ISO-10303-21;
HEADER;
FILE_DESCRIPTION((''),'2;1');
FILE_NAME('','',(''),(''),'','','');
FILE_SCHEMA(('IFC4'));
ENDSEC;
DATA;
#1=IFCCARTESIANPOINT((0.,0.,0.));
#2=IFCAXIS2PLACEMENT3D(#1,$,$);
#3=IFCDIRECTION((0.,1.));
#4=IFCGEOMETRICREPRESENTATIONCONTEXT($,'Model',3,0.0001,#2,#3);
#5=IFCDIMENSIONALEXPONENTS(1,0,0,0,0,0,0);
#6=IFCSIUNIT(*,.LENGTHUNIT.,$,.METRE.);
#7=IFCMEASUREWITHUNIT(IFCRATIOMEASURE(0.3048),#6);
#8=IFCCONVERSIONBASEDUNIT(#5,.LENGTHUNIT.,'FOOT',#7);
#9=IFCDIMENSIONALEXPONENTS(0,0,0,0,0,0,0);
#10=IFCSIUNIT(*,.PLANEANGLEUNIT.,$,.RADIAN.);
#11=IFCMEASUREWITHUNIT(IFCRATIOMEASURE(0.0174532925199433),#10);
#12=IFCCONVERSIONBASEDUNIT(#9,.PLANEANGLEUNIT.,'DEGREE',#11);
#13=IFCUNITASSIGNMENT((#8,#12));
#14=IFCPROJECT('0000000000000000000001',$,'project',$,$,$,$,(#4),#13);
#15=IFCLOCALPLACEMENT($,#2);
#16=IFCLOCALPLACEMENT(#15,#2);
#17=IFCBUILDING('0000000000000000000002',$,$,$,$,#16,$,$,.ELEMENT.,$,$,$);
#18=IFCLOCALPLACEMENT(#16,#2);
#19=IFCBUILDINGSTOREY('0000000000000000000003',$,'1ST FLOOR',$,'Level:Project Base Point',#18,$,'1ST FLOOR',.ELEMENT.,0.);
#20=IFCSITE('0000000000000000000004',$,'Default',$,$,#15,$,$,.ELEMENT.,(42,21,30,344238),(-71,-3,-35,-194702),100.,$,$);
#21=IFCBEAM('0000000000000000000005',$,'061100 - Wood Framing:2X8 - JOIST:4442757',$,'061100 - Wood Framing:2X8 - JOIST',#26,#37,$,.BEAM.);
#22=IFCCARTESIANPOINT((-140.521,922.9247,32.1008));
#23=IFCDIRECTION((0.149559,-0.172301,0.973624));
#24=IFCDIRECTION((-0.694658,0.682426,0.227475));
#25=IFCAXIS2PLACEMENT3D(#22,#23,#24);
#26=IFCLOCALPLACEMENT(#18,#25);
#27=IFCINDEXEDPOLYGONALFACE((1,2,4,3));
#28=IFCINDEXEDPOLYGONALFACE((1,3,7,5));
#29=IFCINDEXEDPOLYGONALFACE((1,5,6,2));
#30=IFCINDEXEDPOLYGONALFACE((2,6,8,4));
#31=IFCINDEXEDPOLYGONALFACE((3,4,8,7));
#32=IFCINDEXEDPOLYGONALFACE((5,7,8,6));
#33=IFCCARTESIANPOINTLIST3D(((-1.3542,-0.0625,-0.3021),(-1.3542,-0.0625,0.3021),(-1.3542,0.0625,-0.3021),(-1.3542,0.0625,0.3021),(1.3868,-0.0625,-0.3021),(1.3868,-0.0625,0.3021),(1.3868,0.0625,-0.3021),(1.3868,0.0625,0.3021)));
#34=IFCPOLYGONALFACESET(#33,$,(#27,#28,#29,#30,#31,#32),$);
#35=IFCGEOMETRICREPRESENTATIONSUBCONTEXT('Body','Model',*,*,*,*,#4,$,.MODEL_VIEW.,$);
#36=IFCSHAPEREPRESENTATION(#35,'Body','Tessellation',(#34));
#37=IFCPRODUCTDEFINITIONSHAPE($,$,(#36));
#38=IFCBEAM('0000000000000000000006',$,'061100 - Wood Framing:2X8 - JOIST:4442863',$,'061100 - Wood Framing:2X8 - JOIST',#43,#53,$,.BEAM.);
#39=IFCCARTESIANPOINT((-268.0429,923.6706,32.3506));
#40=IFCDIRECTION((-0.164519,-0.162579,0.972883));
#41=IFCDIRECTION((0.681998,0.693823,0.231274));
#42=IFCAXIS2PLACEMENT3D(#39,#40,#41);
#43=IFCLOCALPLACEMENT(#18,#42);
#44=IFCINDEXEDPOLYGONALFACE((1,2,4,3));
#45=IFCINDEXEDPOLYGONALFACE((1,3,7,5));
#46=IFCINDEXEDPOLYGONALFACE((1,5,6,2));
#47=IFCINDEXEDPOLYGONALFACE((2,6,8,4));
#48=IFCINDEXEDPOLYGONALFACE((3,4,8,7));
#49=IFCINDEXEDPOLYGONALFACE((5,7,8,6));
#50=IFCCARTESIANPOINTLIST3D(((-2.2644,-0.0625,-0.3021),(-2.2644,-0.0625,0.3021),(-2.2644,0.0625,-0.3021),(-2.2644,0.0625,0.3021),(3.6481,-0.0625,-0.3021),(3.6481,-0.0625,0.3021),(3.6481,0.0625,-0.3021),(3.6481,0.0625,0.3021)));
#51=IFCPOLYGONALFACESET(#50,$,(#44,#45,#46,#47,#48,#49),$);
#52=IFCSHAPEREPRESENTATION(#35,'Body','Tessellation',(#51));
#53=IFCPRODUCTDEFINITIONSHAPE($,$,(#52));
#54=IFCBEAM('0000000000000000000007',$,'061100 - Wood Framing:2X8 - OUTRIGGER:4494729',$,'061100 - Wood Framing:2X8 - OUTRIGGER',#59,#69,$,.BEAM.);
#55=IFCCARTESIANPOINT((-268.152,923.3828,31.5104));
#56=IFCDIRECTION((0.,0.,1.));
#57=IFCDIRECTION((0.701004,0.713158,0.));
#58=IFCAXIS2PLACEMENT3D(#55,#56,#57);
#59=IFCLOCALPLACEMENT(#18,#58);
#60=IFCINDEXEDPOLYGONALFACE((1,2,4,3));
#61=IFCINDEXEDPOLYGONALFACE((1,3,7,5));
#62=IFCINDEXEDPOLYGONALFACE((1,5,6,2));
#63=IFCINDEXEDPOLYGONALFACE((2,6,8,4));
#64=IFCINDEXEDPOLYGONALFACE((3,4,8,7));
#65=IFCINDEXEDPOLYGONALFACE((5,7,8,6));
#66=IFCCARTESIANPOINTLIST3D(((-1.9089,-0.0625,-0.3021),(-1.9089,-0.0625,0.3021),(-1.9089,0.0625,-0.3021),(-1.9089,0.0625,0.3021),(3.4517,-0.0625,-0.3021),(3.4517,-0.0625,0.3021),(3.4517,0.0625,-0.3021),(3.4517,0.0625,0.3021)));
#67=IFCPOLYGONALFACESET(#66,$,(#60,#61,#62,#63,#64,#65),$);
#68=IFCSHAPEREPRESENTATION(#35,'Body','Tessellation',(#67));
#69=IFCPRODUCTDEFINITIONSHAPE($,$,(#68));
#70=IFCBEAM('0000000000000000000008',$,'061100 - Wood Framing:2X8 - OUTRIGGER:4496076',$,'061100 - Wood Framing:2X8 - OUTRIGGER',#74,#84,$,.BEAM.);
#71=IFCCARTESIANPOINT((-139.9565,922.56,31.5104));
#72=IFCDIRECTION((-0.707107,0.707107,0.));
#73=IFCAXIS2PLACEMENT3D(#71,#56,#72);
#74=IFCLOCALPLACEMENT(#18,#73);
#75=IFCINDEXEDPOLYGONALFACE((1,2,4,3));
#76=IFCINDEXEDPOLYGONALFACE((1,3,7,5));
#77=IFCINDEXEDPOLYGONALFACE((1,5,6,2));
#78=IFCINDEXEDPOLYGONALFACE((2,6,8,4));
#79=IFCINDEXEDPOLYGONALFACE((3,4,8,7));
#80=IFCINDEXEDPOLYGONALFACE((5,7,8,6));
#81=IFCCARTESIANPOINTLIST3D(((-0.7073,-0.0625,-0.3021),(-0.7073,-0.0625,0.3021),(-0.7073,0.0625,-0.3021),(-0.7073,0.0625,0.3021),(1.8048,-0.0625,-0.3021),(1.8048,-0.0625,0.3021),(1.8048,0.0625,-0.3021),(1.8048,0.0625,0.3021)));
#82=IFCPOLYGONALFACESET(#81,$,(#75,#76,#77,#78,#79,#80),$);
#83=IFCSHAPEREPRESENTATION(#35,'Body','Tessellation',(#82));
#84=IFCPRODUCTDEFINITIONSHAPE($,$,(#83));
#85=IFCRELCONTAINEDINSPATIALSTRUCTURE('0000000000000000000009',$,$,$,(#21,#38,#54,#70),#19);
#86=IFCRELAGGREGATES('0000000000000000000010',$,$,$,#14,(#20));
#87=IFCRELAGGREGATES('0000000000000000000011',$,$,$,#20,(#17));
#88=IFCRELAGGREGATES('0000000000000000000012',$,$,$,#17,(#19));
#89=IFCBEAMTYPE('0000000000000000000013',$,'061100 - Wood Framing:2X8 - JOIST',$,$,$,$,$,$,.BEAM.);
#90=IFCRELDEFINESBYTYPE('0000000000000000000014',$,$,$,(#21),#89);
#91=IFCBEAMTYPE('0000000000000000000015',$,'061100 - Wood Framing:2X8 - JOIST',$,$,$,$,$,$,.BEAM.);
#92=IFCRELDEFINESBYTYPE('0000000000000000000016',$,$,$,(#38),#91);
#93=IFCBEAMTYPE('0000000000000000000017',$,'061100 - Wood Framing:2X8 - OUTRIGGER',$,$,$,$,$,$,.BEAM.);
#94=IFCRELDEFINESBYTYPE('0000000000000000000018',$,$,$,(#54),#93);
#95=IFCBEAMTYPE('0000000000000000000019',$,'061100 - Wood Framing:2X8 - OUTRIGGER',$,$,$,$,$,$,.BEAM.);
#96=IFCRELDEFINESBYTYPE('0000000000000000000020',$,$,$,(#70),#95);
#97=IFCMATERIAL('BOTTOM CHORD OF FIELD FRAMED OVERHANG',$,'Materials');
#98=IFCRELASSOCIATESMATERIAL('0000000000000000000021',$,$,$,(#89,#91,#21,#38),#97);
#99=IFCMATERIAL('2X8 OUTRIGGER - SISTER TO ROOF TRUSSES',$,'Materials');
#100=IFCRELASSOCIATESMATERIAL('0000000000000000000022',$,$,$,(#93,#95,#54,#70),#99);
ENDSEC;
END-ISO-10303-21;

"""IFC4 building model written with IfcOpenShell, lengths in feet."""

from ifc_helpers import new_model, entity, si_unit, converted_unit, direction, frame, frame_2d, origin, origin_2d_with_axis, place, context, subcontext, project, spatial, rectangle, extrude, source, transform, mapped, material, material_profile, profile_set, profile_usage, type_object, type_shapes, element, save


model = new_model("IFC4")

# Units and contexts
model_context = context("Model", 3, precision=0.0001, world=origin(), true_north=direction((0.0, 1.0)))
body_context = subcontext(model_context, "Body", "Model", "MODEL_VIEW")
ifc_project = project(units=[converted_unit("LENGTHUNIT", "FOOT", entity("IfcRatioMeasure", 0.3048), si_unit("LENGTHUNIT", "METRE"), dimensions=[1, 0, 0, 0, 0, 0, 0]), converted_unit("PLANEANGLEUNIT", "DEGREE", entity("IfcRatioMeasure", 0.0174532925199433), si_unit("PLANEANGLEUNIT", "RADIAN"), dimensions=[0, 0, 0, 0, 0, 0, 0])], contexts=[model_context])

# Site, building, storey
site_placement = place(None, origin())
site = spatial("IfcSite", under=ifc_project, at=site_placement, Name="Default", CompositionType="ELEMENT", RefLatitude=(42, 21, 30, 344238), RefLongitude=(-71, -3, -35, -194702), RefElevation=100.0)
building_placement = place(site_placement, origin())
building = spatial("IfcBuilding", under=site, at=building_placement, CompositionType="ELEMENT")
storey_placement = place(building_placement, origin())
storey = spatial("IfcBuildingStorey", under=building, at=storey_placement, Name="1ST FLOOR", ObjectType="Level:Project Base Point", LongName="1ST FLOOR", CompositionType="ELEMENT", Elevation=0.0)

# Beams
ifc_material_1 = material(Name="BOTTOM CHORD OF FIELD FRAMED OVERHANG", Category="Materials")
ifc_material_profile_1 = material_profile(ifc_material_1, rectangle(XDim=0.6042, YDim=0.125, at=origin_2d_with_axis()), Name="2X8 - JOIST")
ifc_profile_set_1 = profile_set([ifc_material_profile_1], Name="2X8 - JOIST")
ifc_profile_usage_1 = profile_usage(ifc_profile_set_1, cardinal=8)
beam_type_1 = type_object("IfcBeamType", Name="061100 - Wood Framing:2X8 - JOIST", PredefinedType="BEAM", material=ifc_profile_set_1)
shared_shape_1 = source(origin(), body_context, "Body", "SweptSolid", [
    extrude(rectangle(XDim=0.6042, YDim=0.125, at=frame_2d((0.0, 0.0), x_axis=(1.0, 0.0))), frame((-1.3542, 0.0, 0.0), z_axis=(1.0, 0.0, 0.0), x_axis=(0.0, 0.0, -1.0)), (0.0, 0.0, 1.0), 2.7409),
])
type_shapes(beam_type_1, [shared_shape_1])
beam_1_placement = place(storey_placement, frame((-140.521, 922.9247, 32.1008), z_axis=(0.149559, -0.172301, 0.973624), x_axis=(-0.694658, 0.682426, 0.227475)))
element("IfcBeam", 1, at=beam_1_placement, inside=storey, type_object=beam_type_1, material=ifc_profile_usage_1, Name="061100 - Wood Framing:2X8 - JOIST:4442757", ObjectType="061100 - Wood Framing:2X8 - JOIST", PredefinedType="BEAM", context=body_context, shape_type="MappedRepresentation", body=[
    mapped(shared_shape_1, transform((0.0, 0.0, 0.0), scale=1.0)),
])
ifc_profile_usage_2 = profile_usage(ifc_profile_set_1, cardinal=8)
beam_type_2 = type_object("IfcBeamType", Name="061100 - Wood Framing:2X8 - JOIST", PredefinedType="BEAM", material=ifc_profile_set_1)
shared_shape_2 = source(origin(), body_context, "Body", "SweptSolid", [
    extrude(rectangle(XDim=0.6042, YDim=0.125, at=frame_2d((0.0, 0.0), x_axis=(1.0, 0.0))), frame((-2.2644, 0.0, 0.0), z_axis=(1.0, 0.0, 0.0), x_axis=(0.0, 0.0, -1.0)), (0.0, 0.0, 1.0), 5.9125),
])
type_shapes(beam_type_2, [shared_shape_2])
beam_2_placement = place(storey_placement, frame((-268.0429, 923.6706, 32.3506), z_axis=(-0.164519, -0.162579, 0.972883), x_axis=(0.681998, 0.693823, 0.231274)))
element("IfcBeam", 2, at=beam_2_placement, inside=storey, type_object=beam_type_2, material=ifc_profile_usage_2, Name="061100 - Wood Framing:2X8 - JOIST:4442863", ObjectType="061100 - Wood Framing:2X8 - JOIST", PredefinedType="BEAM", context=body_context, shape_type="MappedRepresentation", body=[
    mapped(shared_shape_2, transform((0.0, 0.0, 0.0), scale=1.0)),
])
ifc_material_2 = material(Name="2X8 OUTRIGGER - SISTER TO ROOF TRUSSES", Category="Materials")
ifc_material_profile_2 = material_profile(ifc_material_2, rectangle(XDim=0.6042, YDim=0.125, at=origin_2d_with_axis()), Name="2X8 - OUTRIGGER")
ifc_profile_set_2 = profile_set([ifc_material_profile_2], Name="2X8 - OUTRIGGER")
ifc_profile_usage_3 = profile_usage(ifc_profile_set_2, cardinal=8)
beam_type_3 = type_object("IfcBeamType", Name="061100 - Wood Framing:2X8 - OUTRIGGER", PredefinedType="BEAM", material=ifc_profile_set_2)
shared_shape_3 = source(origin(), body_context, "Body", "SweptSolid", [
    extrude(rectangle(XDim=0.6042, YDim=0.125, at=frame_2d((0.0, 0.0), x_axis=(1.0, 0.0))), frame((-1.9089, 0.0, 0.0), z_axis=(1.0, 0.0, 0.0), x_axis=(0.0, 0.0, -1.0)), (0.0, 0.0, 1.0), 5.3606),
])
type_shapes(beam_type_3, [shared_shape_3])
beam_3_placement = place(storey_placement, frame((-268.152, 923.3828, 31.5104), z_axis=(0.0, 0.0, 1.0), x_axis=(0.701004, 0.713158, 0.0)))
element("IfcBeam", 3, at=beam_3_placement, inside=storey, type_object=beam_type_3, material=ifc_profile_usage_3, Name="061100 - Wood Framing:2X8 - OUTRIGGER:4494729", ObjectType="061100 - Wood Framing:2X8 - OUTRIGGER", PredefinedType="BEAM", context=body_context, shape_type="MappedRepresentation", body=[
    mapped(shared_shape_3, transform((0.0, 0.0, 0.0), scale=1.0)),
])
ifc_profile_usage_4 = profile_usage(ifc_profile_set_2, cardinal=8)
beam_type_4 = type_object("IfcBeamType", Name="061100 - Wood Framing:2X8 - OUTRIGGER", PredefinedType="BEAM", material=ifc_profile_set_2)
shared_shape_4 = source(origin(), body_context, "Body", "SweptSolid", [
    extrude(rectangle(XDim=0.6042, YDim=0.125, at=frame_2d((0.0, 0.0), x_axis=(1.0, 0.0))), frame((-0.7073, 0.0, 0.0), z_axis=(1.0, 0.0, 0.0), x_axis=(0.0, 0.0, -1.0)), (0.0, 0.0, 1.0), 2.5121),
])
type_shapes(beam_type_4, [shared_shape_4])
beam_4_placement = place(storey_placement, frame((-139.9565, 922.56, 31.5104), z_axis=(0.0, 0.0, 1.0), x_axis=(-0.707107, 0.707107, 0.0)))
element("IfcBeam", 4, at=beam_4_placement, inside=storey, type_object=beam_type_4, material=ifc_profile_usage_4, Name="061100 - Wood Framing:2X8 - OUTRIGGER:4496076", ObjectType="061100 - Wood Framing:2X8 - OUTRIGGER", PredefinedType="BEAM", context=body_context, shape_type="MappedRepresentation", body=[
    mapped(shared_shape_4, transform((0.0, 0.0, 0.0), scale=1.0)),
])

save(model, "model.ifc")
